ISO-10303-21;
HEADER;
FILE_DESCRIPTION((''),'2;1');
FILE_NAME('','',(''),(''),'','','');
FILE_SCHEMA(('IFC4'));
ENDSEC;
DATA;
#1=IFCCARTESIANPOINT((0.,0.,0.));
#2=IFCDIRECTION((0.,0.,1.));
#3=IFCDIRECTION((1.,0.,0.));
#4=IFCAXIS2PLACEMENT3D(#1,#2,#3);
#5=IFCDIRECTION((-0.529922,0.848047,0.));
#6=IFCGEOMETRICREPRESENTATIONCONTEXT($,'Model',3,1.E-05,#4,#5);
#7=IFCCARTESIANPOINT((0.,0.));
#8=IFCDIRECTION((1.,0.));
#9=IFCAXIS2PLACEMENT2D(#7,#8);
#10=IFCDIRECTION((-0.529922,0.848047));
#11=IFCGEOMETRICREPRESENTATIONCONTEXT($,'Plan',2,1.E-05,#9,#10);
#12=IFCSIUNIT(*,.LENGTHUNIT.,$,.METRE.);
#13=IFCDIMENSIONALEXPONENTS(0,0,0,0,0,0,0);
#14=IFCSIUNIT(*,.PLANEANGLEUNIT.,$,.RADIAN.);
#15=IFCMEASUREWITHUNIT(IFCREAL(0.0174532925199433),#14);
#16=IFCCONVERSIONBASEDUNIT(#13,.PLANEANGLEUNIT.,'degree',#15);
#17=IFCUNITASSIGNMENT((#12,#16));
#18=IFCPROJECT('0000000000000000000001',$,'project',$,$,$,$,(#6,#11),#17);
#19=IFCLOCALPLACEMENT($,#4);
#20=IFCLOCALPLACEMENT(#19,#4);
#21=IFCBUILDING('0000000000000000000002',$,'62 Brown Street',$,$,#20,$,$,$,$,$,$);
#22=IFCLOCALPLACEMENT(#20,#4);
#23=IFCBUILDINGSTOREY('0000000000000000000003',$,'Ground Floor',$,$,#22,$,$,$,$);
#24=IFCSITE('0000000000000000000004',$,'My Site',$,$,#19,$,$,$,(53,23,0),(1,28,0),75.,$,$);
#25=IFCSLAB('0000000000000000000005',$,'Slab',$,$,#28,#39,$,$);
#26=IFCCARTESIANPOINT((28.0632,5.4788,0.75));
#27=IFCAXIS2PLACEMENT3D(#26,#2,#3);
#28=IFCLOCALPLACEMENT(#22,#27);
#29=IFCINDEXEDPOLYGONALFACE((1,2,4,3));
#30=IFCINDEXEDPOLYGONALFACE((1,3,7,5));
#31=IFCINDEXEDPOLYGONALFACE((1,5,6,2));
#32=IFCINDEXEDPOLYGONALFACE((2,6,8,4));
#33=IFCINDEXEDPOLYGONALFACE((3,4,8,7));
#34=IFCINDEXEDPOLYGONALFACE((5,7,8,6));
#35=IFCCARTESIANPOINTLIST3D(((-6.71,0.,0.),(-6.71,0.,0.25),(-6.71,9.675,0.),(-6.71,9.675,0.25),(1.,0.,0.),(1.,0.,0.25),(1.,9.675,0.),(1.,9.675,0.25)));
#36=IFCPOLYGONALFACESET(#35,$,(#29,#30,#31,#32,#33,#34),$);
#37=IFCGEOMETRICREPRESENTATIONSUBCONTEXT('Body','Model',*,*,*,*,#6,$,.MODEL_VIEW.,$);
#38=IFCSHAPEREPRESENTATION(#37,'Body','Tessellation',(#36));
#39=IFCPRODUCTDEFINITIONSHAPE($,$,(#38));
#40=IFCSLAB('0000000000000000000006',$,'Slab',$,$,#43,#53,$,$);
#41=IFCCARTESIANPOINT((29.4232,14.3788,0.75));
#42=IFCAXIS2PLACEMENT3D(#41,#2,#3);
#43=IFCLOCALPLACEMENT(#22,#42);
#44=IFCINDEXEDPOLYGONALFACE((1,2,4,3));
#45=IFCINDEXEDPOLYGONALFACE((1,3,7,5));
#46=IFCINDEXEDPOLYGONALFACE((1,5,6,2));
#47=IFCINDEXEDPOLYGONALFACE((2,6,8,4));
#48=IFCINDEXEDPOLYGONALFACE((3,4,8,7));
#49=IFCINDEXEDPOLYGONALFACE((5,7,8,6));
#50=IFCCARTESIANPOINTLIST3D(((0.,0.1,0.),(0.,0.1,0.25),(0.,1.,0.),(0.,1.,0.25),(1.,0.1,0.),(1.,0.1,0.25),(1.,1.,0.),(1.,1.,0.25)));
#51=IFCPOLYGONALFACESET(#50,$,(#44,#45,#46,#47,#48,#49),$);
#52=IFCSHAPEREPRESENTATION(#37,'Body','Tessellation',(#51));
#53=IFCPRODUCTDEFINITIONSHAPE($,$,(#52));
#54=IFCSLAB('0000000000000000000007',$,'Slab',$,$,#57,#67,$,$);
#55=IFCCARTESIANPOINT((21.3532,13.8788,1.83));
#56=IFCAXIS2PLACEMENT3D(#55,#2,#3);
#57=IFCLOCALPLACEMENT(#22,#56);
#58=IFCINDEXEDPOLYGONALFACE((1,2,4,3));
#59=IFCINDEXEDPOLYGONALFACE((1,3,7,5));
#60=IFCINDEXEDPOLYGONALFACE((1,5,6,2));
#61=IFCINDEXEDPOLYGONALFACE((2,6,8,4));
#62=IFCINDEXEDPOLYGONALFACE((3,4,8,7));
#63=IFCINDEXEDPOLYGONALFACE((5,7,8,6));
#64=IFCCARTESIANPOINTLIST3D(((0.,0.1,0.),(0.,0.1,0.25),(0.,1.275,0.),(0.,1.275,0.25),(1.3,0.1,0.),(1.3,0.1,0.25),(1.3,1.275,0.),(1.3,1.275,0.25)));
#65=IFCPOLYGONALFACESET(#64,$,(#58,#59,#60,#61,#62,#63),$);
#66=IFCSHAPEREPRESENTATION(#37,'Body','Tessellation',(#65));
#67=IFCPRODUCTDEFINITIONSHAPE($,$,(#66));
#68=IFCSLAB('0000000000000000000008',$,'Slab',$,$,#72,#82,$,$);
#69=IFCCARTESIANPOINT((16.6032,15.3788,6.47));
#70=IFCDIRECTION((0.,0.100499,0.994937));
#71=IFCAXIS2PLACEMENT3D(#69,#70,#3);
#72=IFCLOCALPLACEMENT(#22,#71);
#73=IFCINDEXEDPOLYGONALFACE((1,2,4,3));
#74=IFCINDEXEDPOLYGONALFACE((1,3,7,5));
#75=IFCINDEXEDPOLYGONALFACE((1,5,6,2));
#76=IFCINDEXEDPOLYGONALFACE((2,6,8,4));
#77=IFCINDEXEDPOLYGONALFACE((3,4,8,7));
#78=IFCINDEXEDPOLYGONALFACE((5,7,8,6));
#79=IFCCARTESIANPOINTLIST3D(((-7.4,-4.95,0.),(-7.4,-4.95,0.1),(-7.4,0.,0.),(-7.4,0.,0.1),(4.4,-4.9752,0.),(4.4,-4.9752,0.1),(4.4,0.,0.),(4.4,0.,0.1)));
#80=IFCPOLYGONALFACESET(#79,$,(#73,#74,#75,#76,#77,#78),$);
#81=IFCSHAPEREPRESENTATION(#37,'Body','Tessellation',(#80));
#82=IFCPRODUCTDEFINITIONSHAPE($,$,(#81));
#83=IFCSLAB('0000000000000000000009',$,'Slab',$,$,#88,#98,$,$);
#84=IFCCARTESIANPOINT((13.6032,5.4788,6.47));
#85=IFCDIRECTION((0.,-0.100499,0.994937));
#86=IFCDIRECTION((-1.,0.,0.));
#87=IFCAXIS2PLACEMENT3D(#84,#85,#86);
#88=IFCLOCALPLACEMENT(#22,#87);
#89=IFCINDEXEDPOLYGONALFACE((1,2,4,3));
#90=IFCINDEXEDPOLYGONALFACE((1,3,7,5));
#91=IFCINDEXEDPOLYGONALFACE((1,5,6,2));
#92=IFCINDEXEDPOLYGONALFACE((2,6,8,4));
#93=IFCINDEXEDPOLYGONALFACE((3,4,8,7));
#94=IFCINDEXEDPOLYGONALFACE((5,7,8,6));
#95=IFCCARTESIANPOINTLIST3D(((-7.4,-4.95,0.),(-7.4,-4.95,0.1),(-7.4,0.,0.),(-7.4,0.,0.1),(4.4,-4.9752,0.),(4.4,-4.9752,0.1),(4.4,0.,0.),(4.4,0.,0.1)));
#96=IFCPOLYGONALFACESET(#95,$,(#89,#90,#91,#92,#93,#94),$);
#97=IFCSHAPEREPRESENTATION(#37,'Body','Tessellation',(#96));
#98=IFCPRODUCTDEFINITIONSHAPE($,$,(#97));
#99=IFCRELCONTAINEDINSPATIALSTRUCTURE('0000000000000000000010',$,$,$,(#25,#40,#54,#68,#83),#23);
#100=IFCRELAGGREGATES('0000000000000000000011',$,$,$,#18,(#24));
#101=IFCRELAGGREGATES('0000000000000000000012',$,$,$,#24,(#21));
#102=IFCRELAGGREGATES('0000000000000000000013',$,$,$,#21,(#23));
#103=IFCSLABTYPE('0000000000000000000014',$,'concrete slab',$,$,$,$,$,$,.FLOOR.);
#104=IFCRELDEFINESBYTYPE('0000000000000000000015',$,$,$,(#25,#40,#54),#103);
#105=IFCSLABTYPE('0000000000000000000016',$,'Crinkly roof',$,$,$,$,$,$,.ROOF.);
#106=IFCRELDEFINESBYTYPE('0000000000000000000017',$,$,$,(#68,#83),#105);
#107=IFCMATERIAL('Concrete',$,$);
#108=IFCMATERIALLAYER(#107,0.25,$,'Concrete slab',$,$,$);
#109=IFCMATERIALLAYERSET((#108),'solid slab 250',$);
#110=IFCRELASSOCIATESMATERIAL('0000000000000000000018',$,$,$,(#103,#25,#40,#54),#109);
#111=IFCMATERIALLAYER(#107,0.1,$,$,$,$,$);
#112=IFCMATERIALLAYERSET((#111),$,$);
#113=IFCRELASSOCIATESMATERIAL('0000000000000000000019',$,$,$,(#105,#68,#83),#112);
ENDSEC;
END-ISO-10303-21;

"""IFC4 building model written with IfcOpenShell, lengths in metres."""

from ifc_helpers import new_model, entity, si_unit, converted_unit, direction, frame, origin_with_axes, origin_2d_with_axis, place, context, subcontext, project, spatial, line, indexed_curve, outline, extrude, material, layer, layer_set, layer_usage, type_object, element, save


model = new_model("IFC4")

# Units and contexts
model_context = context("Model", 3, precision=1e-05, world=origin_with_axes(), true_north=direction((-0.529922, 0.848047, 0.0)))
plan_context = context("Plan", 2, precision=1e-05, world=origin_2d_with_axis(), true_north=direction((-0.529922, 0.848047)))
body_context_1 = subcontext(model_context, "Body", "Model", "MODEL_VIEW")
ifc_project = project(units=[si_unit("LENGTHUNIT", "METRE"), converted_unit("PLANEANGLEUNIT", "degree", entity("IfcReal", 0.0174532925199433), si_unit("PLANEANGLEUNIT", "RADIAN"), dimensions=[0, 0, 0, 0, 0, 0, 0])], contexts=[model_context, plan_context])

# Site, building, storey
site_placement = place(None, origin_with_axes())
site = spatial("IfcSite", under=ifc_project, at=site_placement, Name="My Site", RefLatitude=(53, 23, 0), RefLongitude=(1, 28, 0), RefElevation=75.0)
building_placement = place(site_placement, origin_with_axes())
building = spatial("IfcBuilding", under=site, at=building_placement, Name="62 Brown Street")
storey_placement = place(building_placement, origin_with_axes())
storey = spatial("IfcBuildingStorey", under=building, at=storey_placement, Name="Ground Floor")

# Shared definitions
ifc_material_1 = material(Name="Concrete")

# Slabs
ifc_layer_1 = layer(ifc_material_1, 0.25, Name="Concrete slab")
ifc_layer_set_1 = layer_set([ifc_layer_1], Name="solid slab 250")
slab_type_1 = type_object("IfcSlabType", Name="concrete slab", PredefinedType="FLOOR", material=ifc_layer_set_1)
ifc_layer_usage_1 = layer_usage(ifc_layer_set_1, "AXIS3", "POSITIVE", 0.0)
slab_1_placement = place(storey_placement, frame((28.0632, 5.4788, 0.75), z_axis=(0.0, 0.0, 1.0), x_axis=(1.0, 0.0, 0.0)))
element("IfcSlab", 1, at=slab_1_placement, inside=storey, type_object=slab_type_1, material=ifc_layer_usage_1, Name="Slab", context=body_context_1, shape_type="SweptSolid", body=[
    extrude(outline(indexed_curve([(-6.71, 0.0), (-6.71, 9.675), (1.0, 9.675), (1.0, 0.0), (-6.71, 0.0)])), None, (0.0, 0.0, 1.0), 0.25),
])
ifc_layer_usage_2 = layer_usage(ifc_layer_set_1, "AXIS3", "POSITIVE", 0.0)
slab_2_placement = place(storey_placement, frame((29.4232, 14.3788, 0.75), z_axis=(0.0, 0.0, 1.0), x_axis=(1.0, 0.0, 0.0)))
element("IfcSlab", 2, at=slab_2_placement, inside=storey, type_object=slab_type_1, material=ifc_layer_usage_2, Name="Slab", context=body_context_1, shape_type="SweptSolid", body=[
    extrude(outline(indexed_curve([(1.0, 1.0), (1.0, 0.1), (0.0, 0.1), (0.0, 1.0)], segments=[line(3, 2), line(2, 1), line(1, 4), line(4, 3)], self_intersect=False)), None, (0.0, 0.0, 1.0), 0.25),
])
ifc_layer_usage_3 = layer_usage(ifc_layer_set_1, "AXIS3", "POSITIVE", 0.0)
slab_3_placement = place(storey_placement, frame((21.3532, 13.8788, 1.83), z_axis=(0.0, 0.0, 1.0), x_axis=(1.0, 0.0, 0.0)))
element("IfcSlab", 3, at=slab_3_placement, inside=storey, type_object=slab_type_1, material=ifc_layer_usage_3, Name="Slab", context=body_context_1, shape_type="SweptSolid", body=[
    extrude(outline(indexed_curve([(0.0, 0.1), (1.3, 0.1), (1.3, 1.275), (0.0, 1.275), (0.0, 0.1)])), None, (0.0, 0.0, 1.0), 0.25),
])
ifc_layer_2 = layer(ifc_material_1, 0.1)
ifc_layer_set_2 = layer_set([ifc_layer_2])
ifc_layer_usage_4 = layer_usage(ifc_layer_set_2, "AXIS3", "POSITIVE", 0.0)
slab_type_2 = type_object("IfcSlabType", Name="Crinkly roof", PredefinedType="ROOF", material=ifc_layer_set_2)
slab_4_placement = place(storey_placement, frame((16.6032, 15.3788, 6.47), z_axis=(0.0, 0.100499, 0.994937), x_axis=(1.0, 0.0, 0.0)))
element("IfcSlab", 4, at=slab_4_placement, inside=storey, type_object=slab_type_2, material=ifc_layer_usage_4, Name="Slab", context=body_context_1, shape_type="SweptSolid", body=[
    extrude(outline(indexed_curve([(4.4, 0.0), (-7.4, 0.0), (-7.4, -4.95), (4.4, -4.9752), (4.4, 0.0)])), None, (0.0, 0.0, 1.0), 0.1),
])
ifc_layer_usage_5 = layer_usage(ifc_layer_set_2, "AXIS3", "POSITIVE", 0.0)
slab_5_placement = place(storey_placement, frame((13.6032, 5.4788, 6.47), z_axis=(0.0, -0.100499, 0.994937), x_axis=(-1.0, 0.0, 0.0)))
element("IfcSlab", 5, at=slab_5_placement, inside=storey, type_object=slab_type_2, material=ifc_layer_usage_5, Name="Slab", context=body_context_1, shape_type="SweptSolid", body=[
    extrude(outline(indexed_curve([(4.4, 0.0), (-7.4, 0.0), (-7.4, -4.95), (4.4, -4.9752), (4.4, 0.0)])), None, (0.0, 0.0, 1.0), 0.1),
])

save(model, "model.ifc")
